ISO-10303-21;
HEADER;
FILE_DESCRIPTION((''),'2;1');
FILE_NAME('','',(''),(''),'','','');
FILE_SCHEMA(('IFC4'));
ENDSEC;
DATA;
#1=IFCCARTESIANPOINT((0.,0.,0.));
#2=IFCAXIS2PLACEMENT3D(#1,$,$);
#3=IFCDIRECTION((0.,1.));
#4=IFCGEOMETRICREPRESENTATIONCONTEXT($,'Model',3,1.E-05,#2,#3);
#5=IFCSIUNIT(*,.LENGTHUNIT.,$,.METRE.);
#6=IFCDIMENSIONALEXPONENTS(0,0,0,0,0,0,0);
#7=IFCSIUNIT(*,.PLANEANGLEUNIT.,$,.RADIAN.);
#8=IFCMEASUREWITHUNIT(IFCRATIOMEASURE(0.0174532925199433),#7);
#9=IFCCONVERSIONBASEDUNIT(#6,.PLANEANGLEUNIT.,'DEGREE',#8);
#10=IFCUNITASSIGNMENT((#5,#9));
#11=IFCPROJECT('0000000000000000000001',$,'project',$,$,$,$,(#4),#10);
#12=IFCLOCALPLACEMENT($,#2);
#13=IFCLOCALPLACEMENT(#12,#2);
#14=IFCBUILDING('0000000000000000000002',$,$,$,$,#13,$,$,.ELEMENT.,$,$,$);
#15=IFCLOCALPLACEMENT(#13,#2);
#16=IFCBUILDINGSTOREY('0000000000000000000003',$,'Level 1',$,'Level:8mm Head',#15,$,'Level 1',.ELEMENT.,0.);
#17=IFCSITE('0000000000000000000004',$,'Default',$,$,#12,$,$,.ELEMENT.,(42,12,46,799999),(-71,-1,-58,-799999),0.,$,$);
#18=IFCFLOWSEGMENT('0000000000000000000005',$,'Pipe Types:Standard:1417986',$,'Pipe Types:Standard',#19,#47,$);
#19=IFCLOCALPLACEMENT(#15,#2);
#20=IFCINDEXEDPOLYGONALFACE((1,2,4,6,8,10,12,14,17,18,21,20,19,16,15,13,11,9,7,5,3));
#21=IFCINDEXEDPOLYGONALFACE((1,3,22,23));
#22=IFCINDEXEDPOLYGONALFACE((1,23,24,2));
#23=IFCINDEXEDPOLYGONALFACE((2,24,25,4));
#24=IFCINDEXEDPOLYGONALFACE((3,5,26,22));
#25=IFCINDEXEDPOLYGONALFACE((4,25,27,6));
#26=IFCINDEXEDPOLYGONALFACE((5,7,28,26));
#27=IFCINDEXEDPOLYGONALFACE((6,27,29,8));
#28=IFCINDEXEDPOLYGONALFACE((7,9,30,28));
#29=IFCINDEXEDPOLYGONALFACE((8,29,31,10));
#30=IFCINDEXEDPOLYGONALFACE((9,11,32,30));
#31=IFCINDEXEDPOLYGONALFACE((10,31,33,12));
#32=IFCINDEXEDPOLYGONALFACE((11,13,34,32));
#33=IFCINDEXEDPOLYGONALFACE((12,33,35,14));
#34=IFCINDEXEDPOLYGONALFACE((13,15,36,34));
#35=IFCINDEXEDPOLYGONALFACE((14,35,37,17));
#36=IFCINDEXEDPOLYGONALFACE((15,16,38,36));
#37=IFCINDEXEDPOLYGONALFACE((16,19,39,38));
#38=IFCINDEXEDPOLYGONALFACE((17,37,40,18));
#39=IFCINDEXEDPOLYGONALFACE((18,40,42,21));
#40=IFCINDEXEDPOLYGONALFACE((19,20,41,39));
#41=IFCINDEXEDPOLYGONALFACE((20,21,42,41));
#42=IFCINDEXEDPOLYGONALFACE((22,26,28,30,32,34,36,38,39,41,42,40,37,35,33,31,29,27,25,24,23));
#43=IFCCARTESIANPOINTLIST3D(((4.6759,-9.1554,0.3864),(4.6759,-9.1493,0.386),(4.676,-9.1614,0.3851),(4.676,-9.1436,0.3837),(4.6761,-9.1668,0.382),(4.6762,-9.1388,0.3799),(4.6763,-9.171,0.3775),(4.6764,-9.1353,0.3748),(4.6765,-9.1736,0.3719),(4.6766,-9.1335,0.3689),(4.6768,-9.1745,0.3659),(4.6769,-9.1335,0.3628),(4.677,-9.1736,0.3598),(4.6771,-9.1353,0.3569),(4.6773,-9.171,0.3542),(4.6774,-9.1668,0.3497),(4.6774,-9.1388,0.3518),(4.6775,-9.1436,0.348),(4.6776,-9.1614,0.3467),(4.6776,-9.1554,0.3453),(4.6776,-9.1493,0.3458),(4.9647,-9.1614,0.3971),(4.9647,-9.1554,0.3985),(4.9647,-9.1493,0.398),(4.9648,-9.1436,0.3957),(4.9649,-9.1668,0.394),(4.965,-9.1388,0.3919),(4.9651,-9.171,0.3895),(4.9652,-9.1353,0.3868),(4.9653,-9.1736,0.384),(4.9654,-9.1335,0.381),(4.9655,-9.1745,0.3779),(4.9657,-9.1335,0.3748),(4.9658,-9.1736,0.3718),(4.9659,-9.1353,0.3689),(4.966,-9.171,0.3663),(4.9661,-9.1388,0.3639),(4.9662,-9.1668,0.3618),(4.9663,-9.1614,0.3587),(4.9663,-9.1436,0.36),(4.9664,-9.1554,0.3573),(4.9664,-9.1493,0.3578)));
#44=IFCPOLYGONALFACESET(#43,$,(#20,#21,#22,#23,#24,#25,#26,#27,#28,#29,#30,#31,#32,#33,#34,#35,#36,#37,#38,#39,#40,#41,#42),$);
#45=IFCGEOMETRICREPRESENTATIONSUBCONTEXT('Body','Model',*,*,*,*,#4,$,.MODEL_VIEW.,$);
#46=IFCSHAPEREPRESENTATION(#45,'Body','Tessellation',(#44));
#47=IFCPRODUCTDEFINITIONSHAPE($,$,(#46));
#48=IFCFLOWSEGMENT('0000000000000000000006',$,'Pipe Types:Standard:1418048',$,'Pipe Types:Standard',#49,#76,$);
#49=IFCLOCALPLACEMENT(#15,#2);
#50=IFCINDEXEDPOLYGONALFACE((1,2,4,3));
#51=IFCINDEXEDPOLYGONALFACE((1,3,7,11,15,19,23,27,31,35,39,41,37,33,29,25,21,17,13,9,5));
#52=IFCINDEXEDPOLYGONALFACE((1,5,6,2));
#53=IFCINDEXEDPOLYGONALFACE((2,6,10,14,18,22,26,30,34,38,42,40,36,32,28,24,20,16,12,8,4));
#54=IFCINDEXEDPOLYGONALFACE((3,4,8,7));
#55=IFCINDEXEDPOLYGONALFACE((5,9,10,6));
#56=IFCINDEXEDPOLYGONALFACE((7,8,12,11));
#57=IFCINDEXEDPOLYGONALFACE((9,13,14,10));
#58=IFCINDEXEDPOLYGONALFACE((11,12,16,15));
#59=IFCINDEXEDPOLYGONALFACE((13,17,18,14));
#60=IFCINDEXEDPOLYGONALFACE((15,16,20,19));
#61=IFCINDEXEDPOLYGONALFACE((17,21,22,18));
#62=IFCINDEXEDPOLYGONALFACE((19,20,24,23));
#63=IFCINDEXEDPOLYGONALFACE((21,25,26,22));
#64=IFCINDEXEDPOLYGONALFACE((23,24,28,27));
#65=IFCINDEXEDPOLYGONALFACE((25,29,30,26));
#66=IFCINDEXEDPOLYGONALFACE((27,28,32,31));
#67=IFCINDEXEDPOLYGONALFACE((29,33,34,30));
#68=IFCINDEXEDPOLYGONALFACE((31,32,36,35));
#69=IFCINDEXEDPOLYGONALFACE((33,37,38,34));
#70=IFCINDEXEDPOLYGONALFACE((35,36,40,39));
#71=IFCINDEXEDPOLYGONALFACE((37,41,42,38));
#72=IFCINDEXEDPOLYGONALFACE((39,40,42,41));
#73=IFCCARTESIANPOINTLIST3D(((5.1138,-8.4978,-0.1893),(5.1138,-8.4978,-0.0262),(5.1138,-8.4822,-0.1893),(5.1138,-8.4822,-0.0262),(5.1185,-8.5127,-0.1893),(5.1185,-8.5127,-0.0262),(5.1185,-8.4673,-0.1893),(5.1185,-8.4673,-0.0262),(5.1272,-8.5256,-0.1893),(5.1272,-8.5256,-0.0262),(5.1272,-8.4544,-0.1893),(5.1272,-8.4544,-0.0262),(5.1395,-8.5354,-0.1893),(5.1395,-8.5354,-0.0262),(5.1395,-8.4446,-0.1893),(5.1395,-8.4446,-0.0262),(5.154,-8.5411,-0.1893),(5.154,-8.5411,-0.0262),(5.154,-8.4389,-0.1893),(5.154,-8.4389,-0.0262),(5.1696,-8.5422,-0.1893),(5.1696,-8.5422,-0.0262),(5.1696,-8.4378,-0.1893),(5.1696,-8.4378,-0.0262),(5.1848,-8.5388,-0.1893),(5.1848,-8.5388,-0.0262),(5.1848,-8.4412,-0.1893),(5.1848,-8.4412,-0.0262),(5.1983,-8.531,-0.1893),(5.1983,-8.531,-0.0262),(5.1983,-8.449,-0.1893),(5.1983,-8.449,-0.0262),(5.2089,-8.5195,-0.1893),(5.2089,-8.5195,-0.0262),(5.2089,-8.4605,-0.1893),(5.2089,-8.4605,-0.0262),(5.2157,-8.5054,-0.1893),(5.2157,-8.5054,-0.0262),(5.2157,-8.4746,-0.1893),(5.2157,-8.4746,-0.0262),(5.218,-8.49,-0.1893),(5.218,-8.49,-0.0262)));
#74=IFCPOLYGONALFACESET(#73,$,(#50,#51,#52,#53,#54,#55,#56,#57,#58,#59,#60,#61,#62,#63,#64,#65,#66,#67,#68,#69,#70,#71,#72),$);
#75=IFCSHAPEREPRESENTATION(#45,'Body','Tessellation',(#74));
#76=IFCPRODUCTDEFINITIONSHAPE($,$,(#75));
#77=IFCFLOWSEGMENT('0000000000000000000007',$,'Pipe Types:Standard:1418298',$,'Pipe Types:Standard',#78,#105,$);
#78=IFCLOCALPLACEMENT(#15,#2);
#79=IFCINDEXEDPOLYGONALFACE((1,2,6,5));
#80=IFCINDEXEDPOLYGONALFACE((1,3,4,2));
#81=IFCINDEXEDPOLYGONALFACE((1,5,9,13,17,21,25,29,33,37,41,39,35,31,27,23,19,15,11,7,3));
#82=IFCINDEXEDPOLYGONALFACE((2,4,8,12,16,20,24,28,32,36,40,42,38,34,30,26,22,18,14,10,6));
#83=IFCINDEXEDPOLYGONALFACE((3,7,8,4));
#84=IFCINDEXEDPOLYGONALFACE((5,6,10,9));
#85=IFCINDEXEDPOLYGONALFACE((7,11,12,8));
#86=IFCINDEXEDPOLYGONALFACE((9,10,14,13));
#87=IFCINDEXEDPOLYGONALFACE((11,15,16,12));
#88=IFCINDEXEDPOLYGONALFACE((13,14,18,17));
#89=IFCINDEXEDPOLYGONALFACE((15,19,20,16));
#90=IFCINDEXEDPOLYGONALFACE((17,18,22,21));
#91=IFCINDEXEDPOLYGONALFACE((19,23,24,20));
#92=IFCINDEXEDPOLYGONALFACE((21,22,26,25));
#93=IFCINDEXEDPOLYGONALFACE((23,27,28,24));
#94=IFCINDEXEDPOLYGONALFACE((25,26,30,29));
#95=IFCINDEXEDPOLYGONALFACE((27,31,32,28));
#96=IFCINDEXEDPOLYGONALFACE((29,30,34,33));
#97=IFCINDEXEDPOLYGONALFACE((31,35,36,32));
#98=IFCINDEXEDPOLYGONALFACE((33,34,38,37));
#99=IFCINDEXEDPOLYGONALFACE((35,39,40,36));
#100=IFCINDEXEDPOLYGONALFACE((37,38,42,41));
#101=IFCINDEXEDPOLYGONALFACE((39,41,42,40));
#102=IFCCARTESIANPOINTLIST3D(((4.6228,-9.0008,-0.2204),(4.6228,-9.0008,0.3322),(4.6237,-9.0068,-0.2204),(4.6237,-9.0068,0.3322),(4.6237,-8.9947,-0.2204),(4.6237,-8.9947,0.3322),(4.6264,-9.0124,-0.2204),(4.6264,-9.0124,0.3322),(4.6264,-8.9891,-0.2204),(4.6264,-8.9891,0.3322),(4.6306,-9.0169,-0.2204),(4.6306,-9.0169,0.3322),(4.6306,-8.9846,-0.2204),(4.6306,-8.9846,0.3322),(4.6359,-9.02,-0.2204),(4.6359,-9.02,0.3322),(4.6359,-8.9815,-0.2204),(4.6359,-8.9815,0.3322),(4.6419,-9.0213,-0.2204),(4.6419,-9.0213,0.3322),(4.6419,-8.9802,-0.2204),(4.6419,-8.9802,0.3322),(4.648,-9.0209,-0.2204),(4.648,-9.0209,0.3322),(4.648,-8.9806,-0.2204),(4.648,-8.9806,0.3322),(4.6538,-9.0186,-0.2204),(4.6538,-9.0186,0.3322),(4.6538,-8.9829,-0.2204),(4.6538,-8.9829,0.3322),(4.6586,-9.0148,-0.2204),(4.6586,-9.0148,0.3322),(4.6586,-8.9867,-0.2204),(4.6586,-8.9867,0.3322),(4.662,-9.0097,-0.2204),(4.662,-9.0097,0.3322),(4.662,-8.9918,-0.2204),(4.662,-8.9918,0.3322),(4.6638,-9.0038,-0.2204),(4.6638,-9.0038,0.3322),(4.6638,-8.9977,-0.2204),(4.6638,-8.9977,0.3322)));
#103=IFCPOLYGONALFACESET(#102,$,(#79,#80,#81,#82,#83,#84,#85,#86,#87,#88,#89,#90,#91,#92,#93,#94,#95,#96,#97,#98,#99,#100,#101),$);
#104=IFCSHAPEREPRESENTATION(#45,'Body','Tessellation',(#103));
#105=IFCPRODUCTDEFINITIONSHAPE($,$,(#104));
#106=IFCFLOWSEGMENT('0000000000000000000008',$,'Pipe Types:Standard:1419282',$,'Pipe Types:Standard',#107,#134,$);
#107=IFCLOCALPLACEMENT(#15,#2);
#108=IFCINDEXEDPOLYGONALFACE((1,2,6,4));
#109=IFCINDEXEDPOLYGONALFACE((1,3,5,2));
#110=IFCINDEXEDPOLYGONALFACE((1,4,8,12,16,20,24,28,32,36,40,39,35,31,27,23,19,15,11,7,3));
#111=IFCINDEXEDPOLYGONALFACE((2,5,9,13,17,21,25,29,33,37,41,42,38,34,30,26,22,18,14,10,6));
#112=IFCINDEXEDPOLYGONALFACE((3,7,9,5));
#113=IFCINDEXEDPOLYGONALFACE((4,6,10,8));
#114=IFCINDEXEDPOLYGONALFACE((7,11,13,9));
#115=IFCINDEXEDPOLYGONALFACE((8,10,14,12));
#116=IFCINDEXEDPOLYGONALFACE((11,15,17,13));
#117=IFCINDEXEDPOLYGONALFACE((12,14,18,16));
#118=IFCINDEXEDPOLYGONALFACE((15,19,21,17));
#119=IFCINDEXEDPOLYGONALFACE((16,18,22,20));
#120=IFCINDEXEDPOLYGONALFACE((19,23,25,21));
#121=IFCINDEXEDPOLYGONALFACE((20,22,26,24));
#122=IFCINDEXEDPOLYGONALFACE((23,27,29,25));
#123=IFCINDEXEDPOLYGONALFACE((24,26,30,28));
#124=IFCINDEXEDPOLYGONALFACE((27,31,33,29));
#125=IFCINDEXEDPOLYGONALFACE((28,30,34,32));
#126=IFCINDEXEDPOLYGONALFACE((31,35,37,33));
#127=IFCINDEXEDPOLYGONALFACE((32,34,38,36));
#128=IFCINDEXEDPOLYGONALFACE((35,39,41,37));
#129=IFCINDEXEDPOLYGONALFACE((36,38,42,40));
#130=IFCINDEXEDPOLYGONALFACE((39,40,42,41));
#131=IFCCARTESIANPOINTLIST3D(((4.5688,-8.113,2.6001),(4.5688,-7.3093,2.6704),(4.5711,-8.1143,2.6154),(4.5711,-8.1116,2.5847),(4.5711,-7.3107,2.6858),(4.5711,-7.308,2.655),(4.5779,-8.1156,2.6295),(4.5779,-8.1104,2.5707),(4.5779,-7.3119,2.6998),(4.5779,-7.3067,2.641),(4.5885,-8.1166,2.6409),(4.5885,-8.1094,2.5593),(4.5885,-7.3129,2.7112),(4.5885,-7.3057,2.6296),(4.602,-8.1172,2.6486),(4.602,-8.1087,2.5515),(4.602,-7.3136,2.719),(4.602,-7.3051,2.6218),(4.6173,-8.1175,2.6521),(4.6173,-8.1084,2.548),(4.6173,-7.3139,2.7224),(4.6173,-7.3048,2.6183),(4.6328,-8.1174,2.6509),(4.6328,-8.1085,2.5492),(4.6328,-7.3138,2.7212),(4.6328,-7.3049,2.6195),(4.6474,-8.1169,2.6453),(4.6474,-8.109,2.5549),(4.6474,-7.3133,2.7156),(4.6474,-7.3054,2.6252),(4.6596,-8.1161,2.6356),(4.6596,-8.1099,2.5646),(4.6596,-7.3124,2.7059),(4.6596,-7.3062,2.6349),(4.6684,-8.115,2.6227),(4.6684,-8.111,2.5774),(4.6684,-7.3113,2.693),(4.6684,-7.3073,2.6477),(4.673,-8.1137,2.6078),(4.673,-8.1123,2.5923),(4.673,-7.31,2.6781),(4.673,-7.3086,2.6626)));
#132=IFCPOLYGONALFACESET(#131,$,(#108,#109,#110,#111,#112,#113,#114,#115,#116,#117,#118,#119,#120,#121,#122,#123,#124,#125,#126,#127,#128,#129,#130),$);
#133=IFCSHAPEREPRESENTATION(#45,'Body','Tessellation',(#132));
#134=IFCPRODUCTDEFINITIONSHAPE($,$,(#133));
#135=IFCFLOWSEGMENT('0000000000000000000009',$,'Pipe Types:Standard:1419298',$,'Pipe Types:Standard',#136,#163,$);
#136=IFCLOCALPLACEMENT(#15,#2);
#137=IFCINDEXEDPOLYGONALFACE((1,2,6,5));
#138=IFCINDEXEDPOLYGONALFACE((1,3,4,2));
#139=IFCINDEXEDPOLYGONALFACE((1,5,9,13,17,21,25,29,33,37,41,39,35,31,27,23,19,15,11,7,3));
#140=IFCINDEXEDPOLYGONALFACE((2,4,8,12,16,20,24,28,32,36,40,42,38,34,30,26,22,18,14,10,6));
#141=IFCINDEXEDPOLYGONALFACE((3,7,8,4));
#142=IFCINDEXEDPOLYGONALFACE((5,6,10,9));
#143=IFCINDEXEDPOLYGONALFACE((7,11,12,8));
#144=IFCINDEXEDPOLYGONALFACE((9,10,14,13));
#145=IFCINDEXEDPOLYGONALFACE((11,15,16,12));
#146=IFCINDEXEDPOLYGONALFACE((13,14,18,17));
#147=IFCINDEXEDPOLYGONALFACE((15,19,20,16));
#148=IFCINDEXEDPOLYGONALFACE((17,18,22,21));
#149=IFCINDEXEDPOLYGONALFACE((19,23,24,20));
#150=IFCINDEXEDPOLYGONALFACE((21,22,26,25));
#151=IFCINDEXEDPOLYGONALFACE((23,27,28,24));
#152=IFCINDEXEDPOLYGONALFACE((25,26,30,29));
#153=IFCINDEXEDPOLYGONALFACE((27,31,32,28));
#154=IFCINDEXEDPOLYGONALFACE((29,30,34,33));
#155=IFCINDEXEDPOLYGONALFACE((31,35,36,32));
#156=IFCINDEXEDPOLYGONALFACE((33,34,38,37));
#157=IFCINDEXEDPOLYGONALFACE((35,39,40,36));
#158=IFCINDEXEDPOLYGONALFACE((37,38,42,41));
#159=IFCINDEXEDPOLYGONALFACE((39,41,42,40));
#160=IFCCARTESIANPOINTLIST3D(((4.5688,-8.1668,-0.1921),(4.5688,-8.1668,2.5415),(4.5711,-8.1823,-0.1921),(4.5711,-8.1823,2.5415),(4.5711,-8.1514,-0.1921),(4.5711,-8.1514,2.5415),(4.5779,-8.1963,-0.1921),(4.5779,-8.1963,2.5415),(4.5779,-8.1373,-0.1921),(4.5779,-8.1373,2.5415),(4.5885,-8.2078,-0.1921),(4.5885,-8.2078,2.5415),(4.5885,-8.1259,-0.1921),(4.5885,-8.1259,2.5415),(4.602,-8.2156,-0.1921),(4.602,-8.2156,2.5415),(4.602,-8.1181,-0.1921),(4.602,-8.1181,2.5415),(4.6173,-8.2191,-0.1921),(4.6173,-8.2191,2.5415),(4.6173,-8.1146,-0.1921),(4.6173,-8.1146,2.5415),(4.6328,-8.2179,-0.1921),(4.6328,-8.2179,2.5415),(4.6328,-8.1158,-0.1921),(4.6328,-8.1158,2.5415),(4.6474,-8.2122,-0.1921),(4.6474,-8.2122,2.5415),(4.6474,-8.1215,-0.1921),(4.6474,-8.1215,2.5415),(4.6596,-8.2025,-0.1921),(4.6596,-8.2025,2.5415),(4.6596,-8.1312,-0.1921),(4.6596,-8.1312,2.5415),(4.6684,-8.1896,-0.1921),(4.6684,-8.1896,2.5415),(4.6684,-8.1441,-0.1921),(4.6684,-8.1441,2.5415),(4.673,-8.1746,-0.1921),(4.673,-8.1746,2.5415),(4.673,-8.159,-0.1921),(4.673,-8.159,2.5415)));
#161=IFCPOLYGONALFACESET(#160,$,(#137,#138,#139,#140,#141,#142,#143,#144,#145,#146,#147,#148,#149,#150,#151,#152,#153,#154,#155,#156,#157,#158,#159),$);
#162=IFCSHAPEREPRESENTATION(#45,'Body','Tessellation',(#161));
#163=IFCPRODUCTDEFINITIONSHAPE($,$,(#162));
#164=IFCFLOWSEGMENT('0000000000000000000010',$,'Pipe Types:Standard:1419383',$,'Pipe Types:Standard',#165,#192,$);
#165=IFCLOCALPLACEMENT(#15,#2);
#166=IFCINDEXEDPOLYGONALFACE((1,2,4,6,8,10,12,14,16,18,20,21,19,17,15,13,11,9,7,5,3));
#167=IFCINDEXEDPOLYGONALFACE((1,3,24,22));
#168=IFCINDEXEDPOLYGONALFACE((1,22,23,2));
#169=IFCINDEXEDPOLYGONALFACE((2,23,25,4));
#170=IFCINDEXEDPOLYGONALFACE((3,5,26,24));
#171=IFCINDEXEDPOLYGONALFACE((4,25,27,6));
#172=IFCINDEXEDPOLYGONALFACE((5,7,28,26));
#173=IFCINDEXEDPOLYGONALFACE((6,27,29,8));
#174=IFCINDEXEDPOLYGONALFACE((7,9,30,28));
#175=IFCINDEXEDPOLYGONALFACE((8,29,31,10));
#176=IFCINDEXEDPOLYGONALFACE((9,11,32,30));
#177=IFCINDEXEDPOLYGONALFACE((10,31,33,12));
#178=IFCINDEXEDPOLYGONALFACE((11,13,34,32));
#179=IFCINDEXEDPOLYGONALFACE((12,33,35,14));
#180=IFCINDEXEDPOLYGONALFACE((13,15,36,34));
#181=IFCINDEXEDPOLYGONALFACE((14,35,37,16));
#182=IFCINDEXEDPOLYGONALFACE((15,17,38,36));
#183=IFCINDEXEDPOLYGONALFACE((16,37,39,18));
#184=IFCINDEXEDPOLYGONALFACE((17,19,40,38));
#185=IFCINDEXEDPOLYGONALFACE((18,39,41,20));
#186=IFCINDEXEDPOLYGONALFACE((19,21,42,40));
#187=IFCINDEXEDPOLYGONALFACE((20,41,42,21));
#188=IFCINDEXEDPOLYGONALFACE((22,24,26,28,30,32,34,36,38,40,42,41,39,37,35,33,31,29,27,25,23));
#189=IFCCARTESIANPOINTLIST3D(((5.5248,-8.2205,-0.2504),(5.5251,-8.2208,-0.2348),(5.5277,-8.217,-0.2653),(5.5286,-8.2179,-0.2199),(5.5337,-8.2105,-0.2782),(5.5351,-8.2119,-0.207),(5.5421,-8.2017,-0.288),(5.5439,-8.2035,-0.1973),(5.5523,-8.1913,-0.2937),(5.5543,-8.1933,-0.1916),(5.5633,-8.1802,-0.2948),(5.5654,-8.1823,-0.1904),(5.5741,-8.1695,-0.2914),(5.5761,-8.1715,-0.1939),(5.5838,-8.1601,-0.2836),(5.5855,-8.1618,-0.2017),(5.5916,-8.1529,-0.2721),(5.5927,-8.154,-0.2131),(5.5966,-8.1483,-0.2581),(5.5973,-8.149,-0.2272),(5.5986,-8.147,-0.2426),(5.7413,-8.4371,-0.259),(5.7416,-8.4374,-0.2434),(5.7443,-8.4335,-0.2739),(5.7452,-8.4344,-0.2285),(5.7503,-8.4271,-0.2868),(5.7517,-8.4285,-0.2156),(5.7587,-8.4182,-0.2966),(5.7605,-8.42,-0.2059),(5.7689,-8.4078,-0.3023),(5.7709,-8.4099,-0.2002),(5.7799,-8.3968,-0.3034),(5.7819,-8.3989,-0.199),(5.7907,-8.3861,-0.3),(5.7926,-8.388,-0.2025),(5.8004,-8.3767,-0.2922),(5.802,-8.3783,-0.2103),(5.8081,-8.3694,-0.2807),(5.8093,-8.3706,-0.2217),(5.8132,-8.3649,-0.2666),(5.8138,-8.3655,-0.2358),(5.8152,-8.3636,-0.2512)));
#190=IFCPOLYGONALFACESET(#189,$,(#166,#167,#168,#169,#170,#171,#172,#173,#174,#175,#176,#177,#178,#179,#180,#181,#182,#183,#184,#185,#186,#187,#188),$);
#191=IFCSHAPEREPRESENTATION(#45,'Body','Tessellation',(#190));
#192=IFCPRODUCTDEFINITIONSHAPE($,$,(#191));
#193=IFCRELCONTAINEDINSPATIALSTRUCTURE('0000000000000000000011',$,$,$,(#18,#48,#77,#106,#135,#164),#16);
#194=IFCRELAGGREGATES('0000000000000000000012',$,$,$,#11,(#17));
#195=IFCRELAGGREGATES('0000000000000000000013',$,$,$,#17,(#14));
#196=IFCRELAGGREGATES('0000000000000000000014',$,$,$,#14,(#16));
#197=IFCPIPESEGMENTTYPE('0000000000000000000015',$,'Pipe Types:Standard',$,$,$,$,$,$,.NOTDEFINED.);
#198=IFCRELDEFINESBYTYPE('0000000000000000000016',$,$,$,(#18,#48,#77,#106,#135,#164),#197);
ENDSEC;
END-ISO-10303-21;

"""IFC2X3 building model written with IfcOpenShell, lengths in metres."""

from ifc_helpers import new_model, entity, si_unit, converted_unit, direction, frame, frame_2d, origin, origin_2d_with_axis, place, context, subcontext, project, spatial, circle, extrude, type_object, element, save


model = new_model("IFC2X3")

# Units and contexts
model_context = context("Model", 3, precision=1e-05, world=origin(), true_north=direction((0.0, 1.0)))
body_context = subcontext(model_context, "Body", "Model", "MODEL_VIEW")
ifc_project = project(units=[si_unit("LENGTHUNIT", "METRE"), converted_unit("PLANEANGLEUNIT", "DEGREE", entity("IfcRatioMeasure", 0.0174532925199433), si_unit("PLANEANGLEUNIT", "RADIAN"), dimensions=[0, 0, 0, 0, 0, 0, 0])], contexts=[model_context])

# Site, building, storey
site_placement = place(None, origin())
site = spatial("IfcSite", under=ifc_project, at=site_placement, Name="Default", CompositionType="ELEMENT", RefLatitude=(42, 12, 46, 799999), RefLongitude=(-71, -1, -58, -799999), RefElevation=0.0)
building_placement = place(site_placement, origin())
building = spatial("IfcBuilding", under=site, at=building_placement, CompositionType="ELEMENT")
storey_placement = place(building_placement, origin())
storey = spatial("IfcBuildingStorey", under=building, at=storey_placement, Name="Level 1", ObjectType="Level:8mm Head", LongName="Level 1", CompositionType="ELEMENT", Elevation=0.0)

# Flow segments
pipe_segment_type = type_object("IfcPipeSegmentType", Name="Pipe Types:Standard", PredefinedType="NOTDEFINED")
flow_segment_1_placement = place(storey_placement, origin())
element("IfcFlowSegment", 1, at=flow_segment_1_placement, inside=storey, type_object=pipe_segment_type, Name="Pipe Types:Standard:1417986", ObjectType="Pipe Types:Standard", context=body_context, shape_type="SweptSolid", body=[
    extrude(circle(Radius=0.0206, at=frame_2d((0.0, 0.0), x_axis=(1.0, 0.0))), frame((4.6768, -9.1539, 0.3659), z_axis=(0.999133, 0.0, 0.041631), x_axis=(0.0, -1.0, 0.0)), (0.0, 0.0, 1.0), 0.289),
])
flow_segment_2_placement = place(storey_placement, origin())
element("IfcFlowSegment", 2, at=flow_segment_2_placement, inside=storey, type_object=pipe_segment_type, Name="Pipe Types:Standard:1418048", ObjectType="Pipe Types:Standard", context=body_context, shape_type="SweptSolid", body=[
    extrude(circle(Radius=0.0524, at=frame_2d((0.0, 0.0), x_axis=(1.0, 0.0))), frame((5.1656, -8.49, -0.1893)), (0.0, 0.0, 1.0), 0.1631),
])
flow_segment_3_placement = place(storey_placement, origin())
element("IfcFlowSegment", 3, at=flow_segment_3_placement, inside=storey, type_object=pipe_segment_type, Name="Pipe Types:Standard:1418298", ObjectType="Pipe Types:Standard", context=body_context, shape_type="SweptSolid", body=[
    extrude(circle(Radius=0.0206, at=frame_2d((0.0, 0.0), x_axis=(1.0, 0.0))), frame((4.6434, -9.0008, -0.2204), z_axis=(0.0, 0.0, 1.0), x_axis=(-1.0, 0.0, 0.0)), (0.0, 0.0, 1.0), 0.5526),
])
flow_segment_4_placement = place(storey_placement, origin())
element("IfcFlowSegment", 4, at=flow_segment_4_placement, inside=storey, type_object=pipe_segment_type, Name="Pipe Types:Standard:1419282", ObjectType="Pipe Types:Standard", context=body_context, shape_type="SweptSolid", body=[
    extrude(circle(Radius=0.0524, at=frame_2d((0.0, 0.0), x_axis=(1.0, 0.0))), frame((4.6212, -8.113, 2.6001), z_axis=(0.0, 0.996195, 0.087156), x_axis=(-1.0, 0.0, 0.0)), (0.0, 0.0, 1.0), 0.8068),
])
flow_segment_5_placement = place(storey_placement, origin())
element("IfcFlowSegment", 5, at=flow_segment_5_placement, inside=storey, type_object=pipe_segment_type, Name="Pipe Types:Standard:1419298", ObjectType="Pipe Types:Standard", context=body_context, shape_type="SweptSolid", body=[
    extrude(circle(Radius=0.0524, at=origin_2d_with_axis()), frame((4.6212, -8.1668, -0.1921), z_axis=(0.0, 0.0, 1.0), x_axis=(-1.0, 0.0, 0.0)), (0.0, 0.0, 1.0), 2.7336),
])
flow_segment_6_placement = place(storey_placement, origin())
element("IfcFlowSegment", 6, at=flow_segment_6_placement, inside=storey, type_object=pipe_segment_type, Name="Pipe Types:Standard:1419383", ObjectType="Pipe Types:Standard", context=body_context, shape_type="SweptSolid", body=[
    extrude(circle(Radius=0.0524, at=frame_2d((0.0, 0.0), x_axis=(1.0, 0.0))), frame((5.7781, -8.4006, -0.2512), z_axis=(-0.706847, 0.706809, 0.028066), x_axis=(0.707088, 0.707126, 0.0)), (0.0, 0.0, 1.0), 0.3064),
])

save(model, "model.ifc")
